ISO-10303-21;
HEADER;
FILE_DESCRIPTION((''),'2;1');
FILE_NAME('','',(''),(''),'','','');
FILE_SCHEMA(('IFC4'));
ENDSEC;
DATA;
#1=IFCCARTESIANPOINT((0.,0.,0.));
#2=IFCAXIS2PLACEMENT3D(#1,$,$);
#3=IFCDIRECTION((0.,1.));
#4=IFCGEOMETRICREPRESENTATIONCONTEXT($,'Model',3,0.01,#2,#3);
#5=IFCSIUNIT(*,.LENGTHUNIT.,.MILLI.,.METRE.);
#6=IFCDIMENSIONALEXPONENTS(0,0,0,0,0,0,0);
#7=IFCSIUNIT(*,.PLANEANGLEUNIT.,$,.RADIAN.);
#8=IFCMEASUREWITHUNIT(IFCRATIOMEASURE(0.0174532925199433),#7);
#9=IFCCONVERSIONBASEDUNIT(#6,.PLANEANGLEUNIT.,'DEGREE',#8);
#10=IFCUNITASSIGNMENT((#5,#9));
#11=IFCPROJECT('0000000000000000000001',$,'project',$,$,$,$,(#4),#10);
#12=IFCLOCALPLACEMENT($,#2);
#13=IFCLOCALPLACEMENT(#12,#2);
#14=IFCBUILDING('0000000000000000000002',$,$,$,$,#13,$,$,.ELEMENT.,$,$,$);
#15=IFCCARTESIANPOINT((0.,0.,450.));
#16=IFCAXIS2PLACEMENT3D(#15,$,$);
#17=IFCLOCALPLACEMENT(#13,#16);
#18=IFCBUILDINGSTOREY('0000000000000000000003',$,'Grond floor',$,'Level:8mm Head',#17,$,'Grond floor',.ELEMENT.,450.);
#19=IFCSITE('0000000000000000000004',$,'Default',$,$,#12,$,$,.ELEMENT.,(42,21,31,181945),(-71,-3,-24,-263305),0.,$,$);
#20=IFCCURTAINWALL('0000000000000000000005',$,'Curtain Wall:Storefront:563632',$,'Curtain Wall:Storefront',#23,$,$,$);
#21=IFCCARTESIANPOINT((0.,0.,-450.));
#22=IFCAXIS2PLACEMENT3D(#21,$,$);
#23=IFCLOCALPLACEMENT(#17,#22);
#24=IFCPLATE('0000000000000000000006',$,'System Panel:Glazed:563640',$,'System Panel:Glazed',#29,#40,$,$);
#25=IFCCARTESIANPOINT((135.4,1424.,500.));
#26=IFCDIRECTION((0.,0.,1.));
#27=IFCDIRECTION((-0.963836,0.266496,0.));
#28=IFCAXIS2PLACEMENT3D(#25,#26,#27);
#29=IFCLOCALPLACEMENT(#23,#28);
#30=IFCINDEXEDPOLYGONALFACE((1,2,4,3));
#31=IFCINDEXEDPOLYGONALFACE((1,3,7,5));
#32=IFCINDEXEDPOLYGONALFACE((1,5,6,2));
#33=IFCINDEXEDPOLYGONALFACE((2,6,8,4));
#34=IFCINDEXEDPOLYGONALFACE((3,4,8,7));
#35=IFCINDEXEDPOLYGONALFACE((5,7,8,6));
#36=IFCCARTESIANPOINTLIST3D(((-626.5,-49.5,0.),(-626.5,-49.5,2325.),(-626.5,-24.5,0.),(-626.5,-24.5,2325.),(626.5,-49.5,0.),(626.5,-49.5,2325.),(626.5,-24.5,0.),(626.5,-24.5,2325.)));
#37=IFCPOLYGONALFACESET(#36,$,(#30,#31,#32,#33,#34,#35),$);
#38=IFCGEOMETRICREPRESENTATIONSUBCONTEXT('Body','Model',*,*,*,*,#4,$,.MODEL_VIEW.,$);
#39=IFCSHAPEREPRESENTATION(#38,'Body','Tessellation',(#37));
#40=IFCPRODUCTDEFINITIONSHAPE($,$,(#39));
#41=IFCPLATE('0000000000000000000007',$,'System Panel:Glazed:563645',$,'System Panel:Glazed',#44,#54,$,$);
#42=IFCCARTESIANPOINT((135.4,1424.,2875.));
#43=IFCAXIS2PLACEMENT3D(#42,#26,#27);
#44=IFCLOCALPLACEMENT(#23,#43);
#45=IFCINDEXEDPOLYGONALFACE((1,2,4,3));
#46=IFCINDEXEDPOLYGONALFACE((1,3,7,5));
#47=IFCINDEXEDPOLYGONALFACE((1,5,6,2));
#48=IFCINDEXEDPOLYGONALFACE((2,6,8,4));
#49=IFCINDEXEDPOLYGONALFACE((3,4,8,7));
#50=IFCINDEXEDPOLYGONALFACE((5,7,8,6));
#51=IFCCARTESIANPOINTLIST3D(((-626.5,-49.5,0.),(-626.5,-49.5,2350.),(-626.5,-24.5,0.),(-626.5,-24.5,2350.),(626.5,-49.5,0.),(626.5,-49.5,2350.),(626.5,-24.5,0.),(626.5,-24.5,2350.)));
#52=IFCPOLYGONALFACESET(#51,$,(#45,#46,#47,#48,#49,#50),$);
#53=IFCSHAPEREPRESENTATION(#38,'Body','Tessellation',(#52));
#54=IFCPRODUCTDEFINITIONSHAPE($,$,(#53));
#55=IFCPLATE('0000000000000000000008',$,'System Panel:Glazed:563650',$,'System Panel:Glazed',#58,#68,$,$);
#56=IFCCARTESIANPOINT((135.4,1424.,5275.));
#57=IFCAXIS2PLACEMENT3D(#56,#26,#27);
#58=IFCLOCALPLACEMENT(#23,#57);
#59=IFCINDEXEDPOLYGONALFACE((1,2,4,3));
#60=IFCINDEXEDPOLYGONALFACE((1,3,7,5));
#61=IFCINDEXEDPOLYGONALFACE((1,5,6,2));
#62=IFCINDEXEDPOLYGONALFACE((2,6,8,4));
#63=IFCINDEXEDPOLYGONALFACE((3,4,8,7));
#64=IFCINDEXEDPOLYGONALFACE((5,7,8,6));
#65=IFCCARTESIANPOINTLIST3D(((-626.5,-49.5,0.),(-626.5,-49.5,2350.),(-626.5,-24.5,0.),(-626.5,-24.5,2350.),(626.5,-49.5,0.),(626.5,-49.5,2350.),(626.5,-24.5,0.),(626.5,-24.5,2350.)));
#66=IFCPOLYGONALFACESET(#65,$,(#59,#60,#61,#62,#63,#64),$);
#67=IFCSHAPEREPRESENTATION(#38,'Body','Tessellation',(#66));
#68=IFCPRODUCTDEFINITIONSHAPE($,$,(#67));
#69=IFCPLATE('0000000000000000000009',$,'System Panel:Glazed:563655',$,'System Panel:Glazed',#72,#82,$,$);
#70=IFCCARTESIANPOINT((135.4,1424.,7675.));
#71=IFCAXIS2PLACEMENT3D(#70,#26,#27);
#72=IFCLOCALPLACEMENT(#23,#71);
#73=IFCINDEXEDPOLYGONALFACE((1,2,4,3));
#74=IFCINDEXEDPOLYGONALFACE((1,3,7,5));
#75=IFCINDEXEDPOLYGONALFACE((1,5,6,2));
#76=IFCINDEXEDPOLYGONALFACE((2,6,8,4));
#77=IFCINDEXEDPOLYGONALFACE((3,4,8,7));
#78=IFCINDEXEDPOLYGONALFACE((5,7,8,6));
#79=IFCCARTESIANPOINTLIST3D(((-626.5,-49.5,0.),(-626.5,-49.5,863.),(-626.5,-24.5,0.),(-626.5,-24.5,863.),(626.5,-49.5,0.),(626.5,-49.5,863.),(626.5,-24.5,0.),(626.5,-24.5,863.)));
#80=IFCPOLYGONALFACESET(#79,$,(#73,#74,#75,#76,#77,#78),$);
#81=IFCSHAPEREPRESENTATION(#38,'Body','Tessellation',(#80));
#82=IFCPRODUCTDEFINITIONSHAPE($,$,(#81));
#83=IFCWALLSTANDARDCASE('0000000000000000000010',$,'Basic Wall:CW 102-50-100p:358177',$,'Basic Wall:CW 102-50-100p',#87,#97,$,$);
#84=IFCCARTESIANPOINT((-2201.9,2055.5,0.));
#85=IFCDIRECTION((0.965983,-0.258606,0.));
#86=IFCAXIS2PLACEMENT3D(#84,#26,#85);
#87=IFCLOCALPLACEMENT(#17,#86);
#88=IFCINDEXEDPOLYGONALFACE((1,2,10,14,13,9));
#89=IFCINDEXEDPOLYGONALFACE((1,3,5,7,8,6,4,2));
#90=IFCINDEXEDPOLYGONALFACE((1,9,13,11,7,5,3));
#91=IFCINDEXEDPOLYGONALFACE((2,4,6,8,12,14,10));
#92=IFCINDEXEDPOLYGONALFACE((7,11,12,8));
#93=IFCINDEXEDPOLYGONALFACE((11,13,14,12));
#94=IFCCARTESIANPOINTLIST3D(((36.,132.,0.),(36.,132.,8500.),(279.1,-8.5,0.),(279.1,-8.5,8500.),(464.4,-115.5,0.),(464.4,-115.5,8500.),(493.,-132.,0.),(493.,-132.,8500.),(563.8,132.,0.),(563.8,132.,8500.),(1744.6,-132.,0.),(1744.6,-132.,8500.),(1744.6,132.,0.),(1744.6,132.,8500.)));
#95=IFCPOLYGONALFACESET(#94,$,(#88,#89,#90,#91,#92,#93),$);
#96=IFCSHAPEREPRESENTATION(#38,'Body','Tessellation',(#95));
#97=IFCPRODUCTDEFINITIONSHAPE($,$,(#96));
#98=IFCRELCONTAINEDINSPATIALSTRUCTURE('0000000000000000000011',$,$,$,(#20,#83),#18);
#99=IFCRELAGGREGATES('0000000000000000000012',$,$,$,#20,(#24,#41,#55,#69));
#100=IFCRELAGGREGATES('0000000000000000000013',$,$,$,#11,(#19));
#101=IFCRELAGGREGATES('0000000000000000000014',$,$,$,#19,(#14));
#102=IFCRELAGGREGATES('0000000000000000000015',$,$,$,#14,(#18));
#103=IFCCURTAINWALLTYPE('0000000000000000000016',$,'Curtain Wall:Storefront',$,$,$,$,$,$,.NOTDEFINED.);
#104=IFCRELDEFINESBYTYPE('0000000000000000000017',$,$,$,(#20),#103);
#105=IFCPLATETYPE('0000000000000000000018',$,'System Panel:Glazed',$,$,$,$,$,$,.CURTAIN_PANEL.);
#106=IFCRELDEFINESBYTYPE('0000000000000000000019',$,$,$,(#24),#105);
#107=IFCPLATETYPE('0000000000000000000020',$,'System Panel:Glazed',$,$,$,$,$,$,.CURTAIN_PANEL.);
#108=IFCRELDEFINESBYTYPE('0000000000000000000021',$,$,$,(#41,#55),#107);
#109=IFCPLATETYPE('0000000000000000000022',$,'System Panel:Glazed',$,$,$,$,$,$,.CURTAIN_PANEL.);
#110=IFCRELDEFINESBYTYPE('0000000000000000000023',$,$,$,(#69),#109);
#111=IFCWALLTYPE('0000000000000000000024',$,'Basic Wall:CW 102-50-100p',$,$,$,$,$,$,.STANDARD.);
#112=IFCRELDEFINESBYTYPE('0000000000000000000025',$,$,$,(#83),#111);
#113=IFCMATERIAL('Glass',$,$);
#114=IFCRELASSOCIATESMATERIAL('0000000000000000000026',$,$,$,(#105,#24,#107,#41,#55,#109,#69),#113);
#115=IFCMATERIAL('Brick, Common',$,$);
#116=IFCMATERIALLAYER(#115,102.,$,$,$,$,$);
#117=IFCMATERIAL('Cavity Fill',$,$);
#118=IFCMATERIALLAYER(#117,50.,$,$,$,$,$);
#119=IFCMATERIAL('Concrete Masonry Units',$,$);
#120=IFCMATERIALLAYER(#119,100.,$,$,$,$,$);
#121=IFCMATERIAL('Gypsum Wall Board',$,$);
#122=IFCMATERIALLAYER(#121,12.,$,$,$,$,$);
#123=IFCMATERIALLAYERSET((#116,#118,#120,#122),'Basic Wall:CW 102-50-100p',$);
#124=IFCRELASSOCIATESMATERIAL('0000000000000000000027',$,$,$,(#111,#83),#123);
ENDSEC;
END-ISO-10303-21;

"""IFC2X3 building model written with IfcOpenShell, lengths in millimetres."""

from ifc_helpers import new_model, entity, si_unit, converted_unit, direction, frame, frame_2d, origin, place, context, subcontext, project, spatial, polyline, rectangle, outline, extrude, source, transform, mapped, material, layer, layer_set, layer_usage, type_object, type_shapes, element, aggregate, save


model = new_model("IFC2X3")

# Units and contexts
model_context = context("Model", 3, precision=0.01, world=origin(), true_north=direction((0.0, 1.0)))
body_context = subcontext(model_context, "Body", "Model", "MODEL_VIEW")
ifc_project = project(units=[si_unit("LENGTHUNIT", "METRE", prefix="MILLI"), converted_unit("PLANEANGLEUNIT", "DEGREE", entity("IfcRatioMeasure", 0.0174532925199433), si_unit("PLANEANGLEUNIT", "RADIAN"), dimensions=[0, 0, 0, 0, 0, 0, 0])], contexts=[model_context])

# Site, building, storey
site_placement = place(None, origin())
site = spatial("IfcSite", under=ifc_project, at=site_placement, Name="Default", CompositionType="ELEMENT", RefLatitude=(42, 21, 31, 181945), RefLongitude=(-71, -3, -24, -263305), RefElevation=0.0)
building_placement = place(site_placement, origin())
building = spatial("IfcBuilding", under=site, at=building_placement, CompositionType="ELEMENT")
storey_placement = place(building_placement, frame((0.0, 0.0, 450.0)))
storey = spatial("IfcBuildingStorey", under=building, at=storey_placement, Name="Grond floor", ObjectType="Level:8mm Head", LongName="Grond floor", CompositionType="ELEMENT", Elevation=450.0)

# Curtain wall, plates
curtain_wall_type = type_object("IfcCurtainWallType", Name="Curtain Wall:Storefront", PredefinedType="NOTDEFINED")
curtain_wall_placement = place(storey_placement, frame((0.0, 0.0, -450.0)))
curtain_wall = element("IfcCurtainWall", 1, at=curtain_wall_placement, inside=storey, type_object=curtain_wall_type, Name="Curtain Wall:Storefront:563632", ObjectType="Curtain Wall:Storefront")
ifc_material_1 = material(Name="Glass")
plate_type_1 = type_object("IfcPlateType", Name="System Panel:Glazed", PredefinedType="CURTAIN_PANEL", material=ifc_material_1)
shared_shape_1 = source(origin(), body_context, "Body", "SweptSolid", [
    extrude(rectangle(XDim=25.0, YDim=1253.0, at=frame_2d((0.0, 0.0), x_axis=(1.0, 0.0))), frame((0.0, -37.0, 0.0), z_axis=(0.0, 0.0, 1.0), x_axis=(0.0, 1.0, 0.0)), (0.0, 0.0, 1.0), 2325.0),
])
type_shapes(plate_type_1, [shared_shape_1])
plate_1_placement = place(curtain_wall_placement, frame((135.4, 1424.0, 500.0), z_axis=(0.0, 0.0, 1.0), x_axis=(-0.963836, 0.266496, 0.0)))
plate_1 = element("IfcPlate", 2, at=plate_1_placement, type_object=plate_type_1, material=ifc_material_1, Name="System Panel:Glazed:563640", ObjectType="System Panel:Glazed", context=body_context, shape_type="MappedRepresentation", body=[
    mapped(shared_shape_1, transform((0.0, 0.0, 0.0), scale=1.0)),
])
plate_type_2 = type_object("IfcPlateType", Name="System Panel:Glazed", PredefinedType="CURTAIN_PANEL", material=ifc_material_1)
shared_shape_2 = source(origin(), body_context, "Body", "SweptSolid", [
    extrude(rectangle(XDim=25.0, YDim=1253.0, at=frame_2d((0.0, 0.0), x_axis=(1.0, 0.0))), frame((0.0, -37.0, 0.0), z_axis=(0.0, 0.0, 1.0), x_axis=(0.0, 1.0, 0.0)), (0.0, 0.0, 1.0), 2350.0),
])
type_shapes(plate_type_2, [shared_shape_2])
plate_2_placement = place(curtain_wall_placement, frame((135.4, 1424.0, 2875.0), z_axis=(0.0, 0.0, 1.0), x_axis=(-0.963836, 0.266496, 0.0)))
plate_2 = element("IfcPlate", 3, at=plate_2_placement, type_object=plate_type_2, material=ifc_material_1, Name="System Panel:Glazed:563645", ObjectType="System Panel:Glazed", context=body_context, shape_type="MappedRepresentation", body=[
    mapped(shared_shape_2, transform((0.0, 0.0, 0.0), scale=1.0)),
])
plate_3_placement = place(curtain_wall_placement, frame((135.4, 1424.0, 5275.0), z_axis=(0.0, 0.0, 1.0), x_axis=(-0.963836, 0.266496, 0.0)))
plate_3 = element("IfcPlate", 4, at=plate_3_placement, type_object=plate_type_2, material=ifc_material_1, Name="System Panel:Glazed:563650", ObjectType="System Panel:Glazed", context=body_context, shape_type="MappedRepresentation", body=[
    mapped(shared_shape_2, transform((0.0, 0.0, 0.0), scale=1.0)),
])
plate_type_3 = type_object("IfcPlateType", Name="System Panel:Glazed", PredefinedType="CURTAIN_PANEL", material=ifc_material_1)
shared_shape_3 = source(origin(), body_context, "Body", "SweptSolid", [
    extrude(rectangle(XDim=25.0, YDim=1253.0, at=frame_2d((0.0, 0.0), x_axis=(1.0, 0.0))), frame((0.0, -37.0, 0.0), z_axis=(0.0, 0.0, 1.0), x_axis=(0.0, 1.0, 0.0)), (0.0, 0.0, 1.0), 863.0),
])
type_shapes(plate_type_3, [shared_shape_3])
plate_4_placement = place(curtain_wall_placement, frame((135.4, 1424.0, 7675.0), z_axis=(0.0, 0.0, 1.0), x_axis=(-0.963836, 0.266496, 0.0)))
plate_4 = element("IfcPlate", 5, at=plate_4_placement, type_object=plate_type_3, material=ifc_material_1, Name="System Panel:Glazed:563655", ObjectType="System Panel:Glazed", context=body_context, shape_type="MappedRepresentation", body=[
    mapped(shared_shape_3, transform((0.0, 0.0, 0.0), scale=1.0)),
])
aggregate(curtain_wall, [plate_1, plate_2, plate_3, plate_4])

# Wall
ifc_material_2 = material(Name="Brick, Common")
ifc_layer_1 = layer(ifc_material_2, 102.0)
ifc_material_3 = material(Name="Cavity Fill")
ifc_layer_2 = layer(ifc_material_3, 50.0)
ifc_material_4 = material(Name="Concrete Masonry Units")
ifc_layer_3 = layer(ifc_material_4, 100.0)
ifc_material_5 = material(Name="Gypsum Wall Board")
ifc_layer_4 = layer(ifc_material_5, 12.0)
ifc_layer_set = layer_set([ifc_layer_1, ifc_layer_2, ifc_layer_3, ifc_layer_4], Name="Basic Wall:CW 102-50-100p")
ifc_layer_usage = layer_usage(ifc_layer_set, "AXIS2", "NEGATIVE", 132.0)
wall_type = type_object("IfcWallType", Name="Basic Wall:CW 102-50-100p", PredefinedType="STANDARD", material=ifc_layer_set)
wall_placement = place(storey_placement, frame((-2201.9, 2055.5, 0.0), z_axis=(0.0, 0.0, 1.0), x_axis=(0.965983, -0.258606, 0.0)))
element("IfcWallStandardCase", 6, at=wall_placement, inside=storey, type_object=wall_type, material=ifc_layer_usage, Name="Basic Wall:CW 102-50-100p:358177", ObjectType="Basic Wall:CW 102-50-100p", context=body_context, shape_type="SweptSolid", body=[
    extrude(outline(polyline([(1744.6, -132.0), (1744.6, 132.0), (563.8, 132.0), (36.0, 132.0), (279.1, -8.5), (464.4, -115.5), (493.0, -132.0), (1744.6, -132.0)])), origin(), (0.0, 0.0, 1.0), 8500.0),
])

save(model, "model.ifc")
